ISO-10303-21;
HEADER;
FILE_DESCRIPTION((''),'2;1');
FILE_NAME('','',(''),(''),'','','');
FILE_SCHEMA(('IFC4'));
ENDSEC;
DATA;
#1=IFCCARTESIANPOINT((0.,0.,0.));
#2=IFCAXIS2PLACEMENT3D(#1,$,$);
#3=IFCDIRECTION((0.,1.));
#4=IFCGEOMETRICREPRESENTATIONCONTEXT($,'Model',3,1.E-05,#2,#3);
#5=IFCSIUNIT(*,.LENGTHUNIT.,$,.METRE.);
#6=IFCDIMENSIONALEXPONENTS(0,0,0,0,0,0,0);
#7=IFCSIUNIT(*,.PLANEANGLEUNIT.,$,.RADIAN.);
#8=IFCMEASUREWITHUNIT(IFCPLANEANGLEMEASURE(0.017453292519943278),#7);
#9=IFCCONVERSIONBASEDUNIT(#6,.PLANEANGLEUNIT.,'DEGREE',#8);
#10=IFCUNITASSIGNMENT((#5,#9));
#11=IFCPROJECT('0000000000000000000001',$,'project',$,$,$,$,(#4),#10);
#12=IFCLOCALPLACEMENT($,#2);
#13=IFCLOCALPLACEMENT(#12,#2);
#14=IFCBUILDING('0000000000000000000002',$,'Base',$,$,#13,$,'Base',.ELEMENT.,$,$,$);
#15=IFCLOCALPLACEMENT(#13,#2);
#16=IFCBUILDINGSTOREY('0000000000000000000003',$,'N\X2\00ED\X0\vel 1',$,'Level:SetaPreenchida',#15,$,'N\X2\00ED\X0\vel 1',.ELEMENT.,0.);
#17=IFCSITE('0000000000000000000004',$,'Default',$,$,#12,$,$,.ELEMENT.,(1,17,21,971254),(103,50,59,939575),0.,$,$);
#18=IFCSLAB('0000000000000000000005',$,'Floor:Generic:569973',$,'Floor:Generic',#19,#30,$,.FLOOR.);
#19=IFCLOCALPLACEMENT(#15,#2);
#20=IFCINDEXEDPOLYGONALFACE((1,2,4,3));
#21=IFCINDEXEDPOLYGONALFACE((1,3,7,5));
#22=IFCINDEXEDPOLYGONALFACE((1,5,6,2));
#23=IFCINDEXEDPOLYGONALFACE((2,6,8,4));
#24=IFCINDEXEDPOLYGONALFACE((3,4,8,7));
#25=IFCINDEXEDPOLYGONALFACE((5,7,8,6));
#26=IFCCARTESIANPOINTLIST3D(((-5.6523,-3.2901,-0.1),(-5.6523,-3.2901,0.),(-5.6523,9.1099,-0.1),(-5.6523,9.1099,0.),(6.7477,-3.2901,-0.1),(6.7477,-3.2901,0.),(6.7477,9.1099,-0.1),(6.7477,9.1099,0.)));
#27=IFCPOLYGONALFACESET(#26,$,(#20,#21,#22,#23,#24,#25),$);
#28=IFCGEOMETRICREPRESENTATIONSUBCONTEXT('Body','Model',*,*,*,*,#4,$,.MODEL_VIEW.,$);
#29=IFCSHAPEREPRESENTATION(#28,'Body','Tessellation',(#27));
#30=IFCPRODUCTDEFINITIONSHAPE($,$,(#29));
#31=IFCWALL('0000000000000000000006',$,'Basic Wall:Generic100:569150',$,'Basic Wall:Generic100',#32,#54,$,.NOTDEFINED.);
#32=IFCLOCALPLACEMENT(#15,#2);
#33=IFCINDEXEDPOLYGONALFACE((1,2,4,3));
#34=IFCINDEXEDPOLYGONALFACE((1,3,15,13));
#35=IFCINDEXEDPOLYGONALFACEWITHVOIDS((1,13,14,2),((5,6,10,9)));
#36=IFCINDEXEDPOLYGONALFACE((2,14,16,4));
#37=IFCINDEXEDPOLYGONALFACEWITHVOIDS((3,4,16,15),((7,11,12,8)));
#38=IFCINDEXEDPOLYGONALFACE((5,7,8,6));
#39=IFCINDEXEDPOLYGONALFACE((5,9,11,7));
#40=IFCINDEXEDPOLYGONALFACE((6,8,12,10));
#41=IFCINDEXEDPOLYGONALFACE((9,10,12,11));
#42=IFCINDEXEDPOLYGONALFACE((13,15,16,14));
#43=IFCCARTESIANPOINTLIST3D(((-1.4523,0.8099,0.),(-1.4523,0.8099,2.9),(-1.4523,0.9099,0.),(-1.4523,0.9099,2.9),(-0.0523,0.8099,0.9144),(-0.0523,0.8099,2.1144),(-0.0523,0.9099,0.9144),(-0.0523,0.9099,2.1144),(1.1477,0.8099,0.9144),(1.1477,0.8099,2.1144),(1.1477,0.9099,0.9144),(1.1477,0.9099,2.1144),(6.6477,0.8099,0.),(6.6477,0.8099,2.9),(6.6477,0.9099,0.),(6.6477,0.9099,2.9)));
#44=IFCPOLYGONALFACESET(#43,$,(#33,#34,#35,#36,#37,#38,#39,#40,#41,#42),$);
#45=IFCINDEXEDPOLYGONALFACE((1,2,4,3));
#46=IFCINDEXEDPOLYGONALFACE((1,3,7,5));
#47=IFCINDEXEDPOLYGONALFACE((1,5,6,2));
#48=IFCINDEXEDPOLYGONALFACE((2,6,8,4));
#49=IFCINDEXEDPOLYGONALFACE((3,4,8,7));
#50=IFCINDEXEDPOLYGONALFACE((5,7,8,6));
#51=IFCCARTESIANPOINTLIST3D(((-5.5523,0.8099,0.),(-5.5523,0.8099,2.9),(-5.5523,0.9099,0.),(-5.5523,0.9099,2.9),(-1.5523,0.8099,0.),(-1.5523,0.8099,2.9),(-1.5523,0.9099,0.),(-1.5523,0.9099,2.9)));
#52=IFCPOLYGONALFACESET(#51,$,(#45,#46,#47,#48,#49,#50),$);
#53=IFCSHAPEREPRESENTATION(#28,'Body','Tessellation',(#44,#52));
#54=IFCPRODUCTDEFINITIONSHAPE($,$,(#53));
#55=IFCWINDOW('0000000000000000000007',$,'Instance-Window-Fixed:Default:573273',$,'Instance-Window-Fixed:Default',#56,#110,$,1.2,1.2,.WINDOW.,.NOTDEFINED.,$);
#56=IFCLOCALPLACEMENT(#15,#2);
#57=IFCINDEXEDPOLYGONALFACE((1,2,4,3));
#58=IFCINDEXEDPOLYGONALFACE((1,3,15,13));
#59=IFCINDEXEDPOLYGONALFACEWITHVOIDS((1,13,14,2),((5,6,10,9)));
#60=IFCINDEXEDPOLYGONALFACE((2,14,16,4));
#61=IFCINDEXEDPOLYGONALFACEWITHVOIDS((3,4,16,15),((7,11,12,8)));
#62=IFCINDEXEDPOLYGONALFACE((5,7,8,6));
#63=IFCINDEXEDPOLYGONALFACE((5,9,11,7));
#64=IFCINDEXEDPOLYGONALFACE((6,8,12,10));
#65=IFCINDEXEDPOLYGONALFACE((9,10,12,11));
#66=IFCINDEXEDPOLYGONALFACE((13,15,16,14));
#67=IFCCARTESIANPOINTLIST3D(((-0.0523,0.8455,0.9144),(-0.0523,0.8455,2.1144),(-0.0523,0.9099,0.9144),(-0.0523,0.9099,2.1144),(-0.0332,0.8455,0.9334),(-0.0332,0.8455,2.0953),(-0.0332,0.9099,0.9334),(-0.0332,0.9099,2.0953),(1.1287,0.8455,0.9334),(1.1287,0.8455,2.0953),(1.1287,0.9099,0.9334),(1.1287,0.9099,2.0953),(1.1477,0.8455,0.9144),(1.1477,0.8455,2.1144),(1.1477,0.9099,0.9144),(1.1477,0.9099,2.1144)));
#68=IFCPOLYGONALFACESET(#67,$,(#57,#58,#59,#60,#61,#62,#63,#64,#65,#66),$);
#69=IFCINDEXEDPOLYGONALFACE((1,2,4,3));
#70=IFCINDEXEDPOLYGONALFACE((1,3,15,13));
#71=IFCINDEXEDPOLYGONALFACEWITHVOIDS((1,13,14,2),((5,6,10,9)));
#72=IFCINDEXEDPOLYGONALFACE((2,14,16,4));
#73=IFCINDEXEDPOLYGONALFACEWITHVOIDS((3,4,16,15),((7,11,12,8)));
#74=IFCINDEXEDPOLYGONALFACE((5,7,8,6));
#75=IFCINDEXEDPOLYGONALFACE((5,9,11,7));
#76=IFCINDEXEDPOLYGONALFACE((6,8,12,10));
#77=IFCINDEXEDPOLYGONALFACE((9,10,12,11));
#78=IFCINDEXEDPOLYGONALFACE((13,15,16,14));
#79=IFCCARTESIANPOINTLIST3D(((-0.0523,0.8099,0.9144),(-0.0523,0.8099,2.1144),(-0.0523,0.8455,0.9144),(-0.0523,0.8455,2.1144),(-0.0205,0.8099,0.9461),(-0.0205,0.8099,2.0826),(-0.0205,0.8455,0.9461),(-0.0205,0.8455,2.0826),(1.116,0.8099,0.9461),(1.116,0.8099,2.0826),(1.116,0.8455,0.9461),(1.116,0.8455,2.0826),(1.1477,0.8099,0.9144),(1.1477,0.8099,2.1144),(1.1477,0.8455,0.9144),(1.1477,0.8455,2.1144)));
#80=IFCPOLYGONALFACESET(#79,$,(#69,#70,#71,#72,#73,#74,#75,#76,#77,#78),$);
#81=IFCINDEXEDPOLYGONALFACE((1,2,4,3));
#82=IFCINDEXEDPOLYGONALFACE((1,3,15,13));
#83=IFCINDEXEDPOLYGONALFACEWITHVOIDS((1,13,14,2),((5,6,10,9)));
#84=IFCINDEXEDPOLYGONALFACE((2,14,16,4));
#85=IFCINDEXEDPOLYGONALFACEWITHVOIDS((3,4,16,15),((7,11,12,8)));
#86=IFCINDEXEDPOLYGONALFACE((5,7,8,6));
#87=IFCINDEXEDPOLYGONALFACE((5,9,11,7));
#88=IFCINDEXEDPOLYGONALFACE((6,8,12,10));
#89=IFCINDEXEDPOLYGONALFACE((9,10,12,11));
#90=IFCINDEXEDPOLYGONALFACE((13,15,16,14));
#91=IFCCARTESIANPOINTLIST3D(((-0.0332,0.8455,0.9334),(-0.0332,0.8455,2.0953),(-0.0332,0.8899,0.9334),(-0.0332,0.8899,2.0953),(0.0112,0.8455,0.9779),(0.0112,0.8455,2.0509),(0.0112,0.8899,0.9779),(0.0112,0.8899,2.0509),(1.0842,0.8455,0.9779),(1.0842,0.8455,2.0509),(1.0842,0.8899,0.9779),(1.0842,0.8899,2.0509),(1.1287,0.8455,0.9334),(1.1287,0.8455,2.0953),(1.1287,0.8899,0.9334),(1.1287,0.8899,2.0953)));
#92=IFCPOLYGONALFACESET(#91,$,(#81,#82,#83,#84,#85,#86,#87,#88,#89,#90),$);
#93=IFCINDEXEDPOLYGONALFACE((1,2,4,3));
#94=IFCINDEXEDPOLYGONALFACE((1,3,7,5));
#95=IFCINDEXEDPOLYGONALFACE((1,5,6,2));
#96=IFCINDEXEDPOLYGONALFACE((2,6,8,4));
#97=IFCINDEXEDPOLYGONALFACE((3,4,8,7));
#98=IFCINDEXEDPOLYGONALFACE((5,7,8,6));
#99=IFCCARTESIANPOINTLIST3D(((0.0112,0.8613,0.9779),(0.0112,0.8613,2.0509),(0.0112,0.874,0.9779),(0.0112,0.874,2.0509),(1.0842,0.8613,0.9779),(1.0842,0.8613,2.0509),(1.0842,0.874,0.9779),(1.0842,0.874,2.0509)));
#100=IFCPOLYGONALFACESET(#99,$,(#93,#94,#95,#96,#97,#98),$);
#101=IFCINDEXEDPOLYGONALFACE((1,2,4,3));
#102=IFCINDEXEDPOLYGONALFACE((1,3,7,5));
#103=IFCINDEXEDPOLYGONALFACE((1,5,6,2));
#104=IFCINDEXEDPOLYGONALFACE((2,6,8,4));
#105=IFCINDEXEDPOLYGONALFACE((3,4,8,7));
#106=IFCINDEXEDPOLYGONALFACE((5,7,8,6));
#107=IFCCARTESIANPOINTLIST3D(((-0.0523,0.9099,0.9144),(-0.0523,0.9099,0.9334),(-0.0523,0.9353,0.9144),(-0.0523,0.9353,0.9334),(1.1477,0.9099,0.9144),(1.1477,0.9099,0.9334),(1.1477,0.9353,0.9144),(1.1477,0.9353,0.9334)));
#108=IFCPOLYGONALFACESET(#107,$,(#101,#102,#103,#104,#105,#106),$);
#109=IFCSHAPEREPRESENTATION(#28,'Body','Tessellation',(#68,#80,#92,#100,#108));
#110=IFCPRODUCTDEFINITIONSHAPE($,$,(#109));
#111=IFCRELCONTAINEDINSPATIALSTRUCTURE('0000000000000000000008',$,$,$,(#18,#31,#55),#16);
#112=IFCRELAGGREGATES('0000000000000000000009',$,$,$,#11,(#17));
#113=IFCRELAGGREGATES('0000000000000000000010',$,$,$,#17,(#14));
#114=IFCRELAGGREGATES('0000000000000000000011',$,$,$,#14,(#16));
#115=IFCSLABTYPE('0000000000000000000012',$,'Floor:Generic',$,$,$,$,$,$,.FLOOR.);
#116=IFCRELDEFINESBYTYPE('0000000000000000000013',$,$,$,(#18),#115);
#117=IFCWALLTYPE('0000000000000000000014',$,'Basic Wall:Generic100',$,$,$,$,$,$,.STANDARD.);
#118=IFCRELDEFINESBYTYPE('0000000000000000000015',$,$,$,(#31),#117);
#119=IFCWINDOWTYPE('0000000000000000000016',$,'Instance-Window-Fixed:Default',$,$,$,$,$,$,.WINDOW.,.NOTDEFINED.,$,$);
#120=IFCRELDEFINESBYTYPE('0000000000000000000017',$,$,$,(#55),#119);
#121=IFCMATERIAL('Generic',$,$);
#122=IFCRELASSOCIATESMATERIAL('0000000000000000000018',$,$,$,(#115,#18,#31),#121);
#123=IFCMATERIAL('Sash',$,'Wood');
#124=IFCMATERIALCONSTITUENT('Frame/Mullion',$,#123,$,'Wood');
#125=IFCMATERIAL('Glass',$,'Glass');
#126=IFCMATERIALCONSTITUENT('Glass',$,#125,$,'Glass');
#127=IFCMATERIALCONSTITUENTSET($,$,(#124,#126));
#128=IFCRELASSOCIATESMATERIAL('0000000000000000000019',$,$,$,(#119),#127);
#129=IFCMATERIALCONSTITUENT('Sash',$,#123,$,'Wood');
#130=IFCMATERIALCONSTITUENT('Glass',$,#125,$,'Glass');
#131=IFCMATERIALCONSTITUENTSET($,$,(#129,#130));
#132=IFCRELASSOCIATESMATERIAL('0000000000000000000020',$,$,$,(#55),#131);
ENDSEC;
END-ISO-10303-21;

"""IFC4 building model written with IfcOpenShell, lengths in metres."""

from ifc_helpers import new_model, entity, si_unit, converted_unit, direction, frame, origin, place, context, subcontext, project, spatial, indexed_curve, outline, extrude, source, transform, mapped, material, constituent, constituent_set, type_object, type_shapes, element, fill, save


model = new_model("IFC4")

# Units and contexts
model_context = context("Model", 3, precision=1e-05, world=origin(), true_north=direction((0.0, 1.0)))
body_context = subcontext(model_context, "Body", "Model", "MODEL_VIEW")
ifc_project = project(units=[si_unit("LENGTHUNIT", "METRE"), converted_unit("PLANEANGLEUNIT", "DEGREE", entity("IfcPlaneAngleMeasure", 0.017453292519943278), si_unit("PLANEANGLEUNIT", "RADIAN"), dimensions=[0, 0, 0, 0, 0, 0, 0])], contexts=[model_context])

# Site, building, storey
site_placement = place(None, origin())
site = spatial("IfcSite", under=ifc_project, at=site_placement, Name="Default", CompositionType="ELEMENT", RefLatitude=(1, 17, 21, 971254), RefLongitude=(103, 50, 59, 939575), RefElevation=0.0)
building_placement = place(site_placement, origin())
building = spatial("IfcBuilding", under=site, at=building_placement, Name="Base", LongName="Base", CompositionType="ELEMENT")
storey_placement = place(building_placement, origin())
storey = spatial("IfcBuildingStorey", under=building, at=storey_placement, Name="Nível 1", ObjectType="Level:SetaPreenchida", LongName="Nível 1", CompositionType="ELEMENT", Elevation=0.0)

# Slab
ifc_material_1 = material(Name="Generic")
slab_type = type_object("IfcSlabType", Name="Floor:Generic", PredefinedType="FLOOR", material=ifc_material_1)
slab_placement = place(storey_placement, origin())
element("IfcSlab", 1, at=slab_placement, inside=storey, type_object=slab_type, material=ifc_material_1, Name="Floor:Generic:569973", ObjectType="Floor:Generic", PredefinedType="FLOOR", context=body_context, shape_type="SweptSolid", body=[
    extrude(outline(indexed_curve([(-6.2, -6.2), (6.2, -6.2), (6.2, 6.2), (-6.2, 6.2), (-6.2, -6.2)], self_intersect=False)), frame((0.5477, 2.9099, 0.0), z_axis=(0.0, 0.0, -1.0), x_axis=(0.0, 1.0, 0.0)), (0.0, 0.0, 1.0), 0.1),
])

# Wall, openings, window
wall_type = type_object("IfcWallType", Name="Basic Wall:Generic100", PredefinedType="STANDARD")
wall_placement = place(storey_placement, frame((6.6477, 0.8599, 0.0), z_axis=(0.0, 0.0, 1.0), x_axis=(-1.0, 0.0, 0.0)))
wall = element("IfcWall", 2, at=wall_placement, inside=storey, type_object=wall_type, material=ifc_material_1, Name="Basic Wall:Generic100:569150", ObjectType="Basic Wall:Generic100", PredefinedType="NOTDEFINED", context=body_context, shape_type="SweptSolid", body=[
    extrude(outline(indexed_curve([(-4.05, -0.05), (-0.05, -0.05), (0.05, -0.05), (4.05, -0.05), (4.05, 0.05), (0.05, 0.05), (-0.05, 0.05), (-4.05, 0.05), (-4.05, -0.05)], self_intersect=False)), frame((4.05, 0.0, 0.0)), (0.0, 0.0, 1.0), 2.9),
    extrude(outline(indexed_curve([(-2.0, -0.05), (2.0, -0.05), (2.0, 0.05), (-2.0, 0.05), (-2.0, -0.05)], self_intersect=False)), frame((10.2, 0.0, 0.0), z_axis=(0.0, 0.0, 1.0), x_axis=(-1.0, 0.0, 0.0)), (0.0, 0.0, 1.0), 2.9),
])
opening_1_placement = place(storey_placement, frame((6.6477, 0.8599, 0.0), z_axis=(0.0, 0.0, 1.0), x_axis=(-1.0, 0.0, 0.0)))
element("IfcOpeningElement", 3, at=opening_1_placement, cuts=wall, PredefinedType="OPENING", context=body_context, shape_type="SweptSolid", body=[
    extrude(outline(indexed_curve([(-0.6, -0.6), (0.6, -0.6), (0.6, 0.6), (-0.6, 0.6), (-0.6, -0.6)], self_intersect=False)), frame((6.1, -0.05, 1.5144), z_axis=(0.0, 1.0, 0.0), x_axis=(0.0, 0.0, 1.0)), (0.0, 0.0, 1.0), 0.1),
])
opening_2_placement = place(wall_placement, frame((6.7, 0.05, 0.9144)))
opening_2 = element("IfcOpeningElement", 4, at=opening_2_placement, cuts=wall, PredefinedType="OPENING", context=body_context, shape_type="SweptSolid", body=[
    extrude(outline(indexed_curve([(1.2, 1.2), (0.0, 1.2), (0.0, 0.0), (1.2, 0.0), (1.2, 1.2)], self_intersect=False)), frame((0.0, 0.0, 0.0), z_axis=(0.0, -1.0, 0.0), x_axis=(0.0, 0.0, 1.0)), (0.0, 0.0, 1.0), 0.1),
])
ifc_material_2 = material(Name="Sash", Category="Wood")
ifc_constituent_1 = constituent(ifc_material_2, Name="Sash", Category="Wood")
ifc_material_3 = material(Name="Glass", Category="Glass")
ifc_constituent_2 = constituent(ifc_material_3, Name="Glass", Category="Glass")
ifc_constituent_set_1 = constituent_set(constituents=[ifc_constituent_1, ifc_constituent_2])
ifc_constituent_3 = constituent(ifc_material_2, Name="Frame/Mullion", Category="Wood")
ifc_constituent_4 = constituent(ifc_material_3, Name="Glass", Category="Glass")
ifc_constituent_set_2 = constituent_set(constituents=[ifc_constituent_3, ifc_constituent_4])
window_type = type_object("IfcWindowType", Name="Instance-Window-Fixed:Default", PartitioningType="NOTDEFINED", PredefinedType="WINDOW", material=ifc_constituent_set_2)
shared_shape = source(origin(), body_context, "Body", "SweptSolid", [
    extrude(outline(indexed_curve([(-0.6, -0.6), (0.6, -0.6), (0.6, 0.6), (-0.6, 0.6), (-0.6, -0.6)], self_intersect=False), holes=[indexed_curve([(-0.5809, -0.5809), (-0.5809, 0.581), (0.581, 0.581), (0.581, -0.5809), (-0.5809, -0.5809)], self_intersect=False)]), frame((0.6, 0.0356, 0.6), z_axis=(0.0, 1.0, 0.0), x_axis=(0.0, 0.0, -1.0)), (0.0, 0.0, 1.0), 0.0644),
    extrude(outline(indexed_curve([(-0.6, -0.6), (0.6, -0.6), (0.6, 0.6), (-0.6, 0.6), (-0.6, -0.6)], self_intersect=False), holes=[indexed_curve([(-0.5683, -0.5682), (-0.5683, 0.5683), (0.5682, 0.5683), (0.5682, -0.5682), (-0.5683, -0.5682)], self_intersect=False)]), frame((0.6, 0.0, 0.6), z_axis=(0.0, 1.0, 0.0), x_axis=(1.0, 0.0, 0.0)), (0.0, 0.0, 1.0), 0.0356),
    extrude(outline(indexed_curve([(-0.5809, -0.581), (0.5809, -0.581), (0.5809, 0.581), (-0.5809, 0.581), (-0.5809, -0.581)], self_intersect=False), holes=[indexed_curve([(-0.5365, -0.5365), (-0.5365, 0.5365), (0.5365, 0.5365), (0.5365, -0.5365), (-0.5365, -0.5365)], self_intersect=False)]), frame((0.6, 0.0356, 0.6), z_axis=(0.0, 1.0, 0.0), x_axis=(1.0, 0.0, 0.0)), (0.0, 0.0, 1.0), 0.0444),
    extrude(outline(indexed_curve([(-0.0063, -0.5365), (0.0063, -0.5365), (0.0063, 0.5365), (-0.0063, 0.5365), (-0.0063, -0.5365)], self_intersect=False)), frame((0.6, 0.0578, 0.0635), z_axis=(0.0, 0.0, 1.0), x_axis=(0.0, 1.0, 0.0)), (0.0, 0.0, 1.0), 1.073),
    extrude(outline(indexed_curve([(-0.0127, -0.6), (0.0127, -0.6), (0.0127, 0.6), (-0.0127, 0.6), (-0.0127, -0.6)], self_intersect=False)), frame((0.6, 0.1127, 0.0), z_axis=(0.0, 0.0, 1.0), x_axis=(0.0, -1.0, 0.0)), (0.0, 0.0, 1.0), 0.019),
])
type_shapes(window_type, [shared_shape])
window_placement = place(opening_2_placement, frame((0.0, 0.0, 0.0), z_axis=(0.0, 0.0, 1.0), x_axis=(-1.0, 0.0, 0.0)))
window = element("IfcWindow", 5, at=window_placement, inside=storey, type_object=window_type, material=ifc_constituent_set_1, Name="Instance-Window-Fixed:Default:573273", ObjectType="Instance-Window-Fixed:Default", OverallHeight=1.2, OverallWidth=1.2, PartitioningType="NOTDEFINED", PredefinedType="WINDOW", context=body_context, shape_type="MappedRepresentation", body=[
    mapped(shared_shape, transform((0.0, 0.0, 0.0), scale=1.0)),
])
fill(opening_2, window)

save(model, "model.ifc")
